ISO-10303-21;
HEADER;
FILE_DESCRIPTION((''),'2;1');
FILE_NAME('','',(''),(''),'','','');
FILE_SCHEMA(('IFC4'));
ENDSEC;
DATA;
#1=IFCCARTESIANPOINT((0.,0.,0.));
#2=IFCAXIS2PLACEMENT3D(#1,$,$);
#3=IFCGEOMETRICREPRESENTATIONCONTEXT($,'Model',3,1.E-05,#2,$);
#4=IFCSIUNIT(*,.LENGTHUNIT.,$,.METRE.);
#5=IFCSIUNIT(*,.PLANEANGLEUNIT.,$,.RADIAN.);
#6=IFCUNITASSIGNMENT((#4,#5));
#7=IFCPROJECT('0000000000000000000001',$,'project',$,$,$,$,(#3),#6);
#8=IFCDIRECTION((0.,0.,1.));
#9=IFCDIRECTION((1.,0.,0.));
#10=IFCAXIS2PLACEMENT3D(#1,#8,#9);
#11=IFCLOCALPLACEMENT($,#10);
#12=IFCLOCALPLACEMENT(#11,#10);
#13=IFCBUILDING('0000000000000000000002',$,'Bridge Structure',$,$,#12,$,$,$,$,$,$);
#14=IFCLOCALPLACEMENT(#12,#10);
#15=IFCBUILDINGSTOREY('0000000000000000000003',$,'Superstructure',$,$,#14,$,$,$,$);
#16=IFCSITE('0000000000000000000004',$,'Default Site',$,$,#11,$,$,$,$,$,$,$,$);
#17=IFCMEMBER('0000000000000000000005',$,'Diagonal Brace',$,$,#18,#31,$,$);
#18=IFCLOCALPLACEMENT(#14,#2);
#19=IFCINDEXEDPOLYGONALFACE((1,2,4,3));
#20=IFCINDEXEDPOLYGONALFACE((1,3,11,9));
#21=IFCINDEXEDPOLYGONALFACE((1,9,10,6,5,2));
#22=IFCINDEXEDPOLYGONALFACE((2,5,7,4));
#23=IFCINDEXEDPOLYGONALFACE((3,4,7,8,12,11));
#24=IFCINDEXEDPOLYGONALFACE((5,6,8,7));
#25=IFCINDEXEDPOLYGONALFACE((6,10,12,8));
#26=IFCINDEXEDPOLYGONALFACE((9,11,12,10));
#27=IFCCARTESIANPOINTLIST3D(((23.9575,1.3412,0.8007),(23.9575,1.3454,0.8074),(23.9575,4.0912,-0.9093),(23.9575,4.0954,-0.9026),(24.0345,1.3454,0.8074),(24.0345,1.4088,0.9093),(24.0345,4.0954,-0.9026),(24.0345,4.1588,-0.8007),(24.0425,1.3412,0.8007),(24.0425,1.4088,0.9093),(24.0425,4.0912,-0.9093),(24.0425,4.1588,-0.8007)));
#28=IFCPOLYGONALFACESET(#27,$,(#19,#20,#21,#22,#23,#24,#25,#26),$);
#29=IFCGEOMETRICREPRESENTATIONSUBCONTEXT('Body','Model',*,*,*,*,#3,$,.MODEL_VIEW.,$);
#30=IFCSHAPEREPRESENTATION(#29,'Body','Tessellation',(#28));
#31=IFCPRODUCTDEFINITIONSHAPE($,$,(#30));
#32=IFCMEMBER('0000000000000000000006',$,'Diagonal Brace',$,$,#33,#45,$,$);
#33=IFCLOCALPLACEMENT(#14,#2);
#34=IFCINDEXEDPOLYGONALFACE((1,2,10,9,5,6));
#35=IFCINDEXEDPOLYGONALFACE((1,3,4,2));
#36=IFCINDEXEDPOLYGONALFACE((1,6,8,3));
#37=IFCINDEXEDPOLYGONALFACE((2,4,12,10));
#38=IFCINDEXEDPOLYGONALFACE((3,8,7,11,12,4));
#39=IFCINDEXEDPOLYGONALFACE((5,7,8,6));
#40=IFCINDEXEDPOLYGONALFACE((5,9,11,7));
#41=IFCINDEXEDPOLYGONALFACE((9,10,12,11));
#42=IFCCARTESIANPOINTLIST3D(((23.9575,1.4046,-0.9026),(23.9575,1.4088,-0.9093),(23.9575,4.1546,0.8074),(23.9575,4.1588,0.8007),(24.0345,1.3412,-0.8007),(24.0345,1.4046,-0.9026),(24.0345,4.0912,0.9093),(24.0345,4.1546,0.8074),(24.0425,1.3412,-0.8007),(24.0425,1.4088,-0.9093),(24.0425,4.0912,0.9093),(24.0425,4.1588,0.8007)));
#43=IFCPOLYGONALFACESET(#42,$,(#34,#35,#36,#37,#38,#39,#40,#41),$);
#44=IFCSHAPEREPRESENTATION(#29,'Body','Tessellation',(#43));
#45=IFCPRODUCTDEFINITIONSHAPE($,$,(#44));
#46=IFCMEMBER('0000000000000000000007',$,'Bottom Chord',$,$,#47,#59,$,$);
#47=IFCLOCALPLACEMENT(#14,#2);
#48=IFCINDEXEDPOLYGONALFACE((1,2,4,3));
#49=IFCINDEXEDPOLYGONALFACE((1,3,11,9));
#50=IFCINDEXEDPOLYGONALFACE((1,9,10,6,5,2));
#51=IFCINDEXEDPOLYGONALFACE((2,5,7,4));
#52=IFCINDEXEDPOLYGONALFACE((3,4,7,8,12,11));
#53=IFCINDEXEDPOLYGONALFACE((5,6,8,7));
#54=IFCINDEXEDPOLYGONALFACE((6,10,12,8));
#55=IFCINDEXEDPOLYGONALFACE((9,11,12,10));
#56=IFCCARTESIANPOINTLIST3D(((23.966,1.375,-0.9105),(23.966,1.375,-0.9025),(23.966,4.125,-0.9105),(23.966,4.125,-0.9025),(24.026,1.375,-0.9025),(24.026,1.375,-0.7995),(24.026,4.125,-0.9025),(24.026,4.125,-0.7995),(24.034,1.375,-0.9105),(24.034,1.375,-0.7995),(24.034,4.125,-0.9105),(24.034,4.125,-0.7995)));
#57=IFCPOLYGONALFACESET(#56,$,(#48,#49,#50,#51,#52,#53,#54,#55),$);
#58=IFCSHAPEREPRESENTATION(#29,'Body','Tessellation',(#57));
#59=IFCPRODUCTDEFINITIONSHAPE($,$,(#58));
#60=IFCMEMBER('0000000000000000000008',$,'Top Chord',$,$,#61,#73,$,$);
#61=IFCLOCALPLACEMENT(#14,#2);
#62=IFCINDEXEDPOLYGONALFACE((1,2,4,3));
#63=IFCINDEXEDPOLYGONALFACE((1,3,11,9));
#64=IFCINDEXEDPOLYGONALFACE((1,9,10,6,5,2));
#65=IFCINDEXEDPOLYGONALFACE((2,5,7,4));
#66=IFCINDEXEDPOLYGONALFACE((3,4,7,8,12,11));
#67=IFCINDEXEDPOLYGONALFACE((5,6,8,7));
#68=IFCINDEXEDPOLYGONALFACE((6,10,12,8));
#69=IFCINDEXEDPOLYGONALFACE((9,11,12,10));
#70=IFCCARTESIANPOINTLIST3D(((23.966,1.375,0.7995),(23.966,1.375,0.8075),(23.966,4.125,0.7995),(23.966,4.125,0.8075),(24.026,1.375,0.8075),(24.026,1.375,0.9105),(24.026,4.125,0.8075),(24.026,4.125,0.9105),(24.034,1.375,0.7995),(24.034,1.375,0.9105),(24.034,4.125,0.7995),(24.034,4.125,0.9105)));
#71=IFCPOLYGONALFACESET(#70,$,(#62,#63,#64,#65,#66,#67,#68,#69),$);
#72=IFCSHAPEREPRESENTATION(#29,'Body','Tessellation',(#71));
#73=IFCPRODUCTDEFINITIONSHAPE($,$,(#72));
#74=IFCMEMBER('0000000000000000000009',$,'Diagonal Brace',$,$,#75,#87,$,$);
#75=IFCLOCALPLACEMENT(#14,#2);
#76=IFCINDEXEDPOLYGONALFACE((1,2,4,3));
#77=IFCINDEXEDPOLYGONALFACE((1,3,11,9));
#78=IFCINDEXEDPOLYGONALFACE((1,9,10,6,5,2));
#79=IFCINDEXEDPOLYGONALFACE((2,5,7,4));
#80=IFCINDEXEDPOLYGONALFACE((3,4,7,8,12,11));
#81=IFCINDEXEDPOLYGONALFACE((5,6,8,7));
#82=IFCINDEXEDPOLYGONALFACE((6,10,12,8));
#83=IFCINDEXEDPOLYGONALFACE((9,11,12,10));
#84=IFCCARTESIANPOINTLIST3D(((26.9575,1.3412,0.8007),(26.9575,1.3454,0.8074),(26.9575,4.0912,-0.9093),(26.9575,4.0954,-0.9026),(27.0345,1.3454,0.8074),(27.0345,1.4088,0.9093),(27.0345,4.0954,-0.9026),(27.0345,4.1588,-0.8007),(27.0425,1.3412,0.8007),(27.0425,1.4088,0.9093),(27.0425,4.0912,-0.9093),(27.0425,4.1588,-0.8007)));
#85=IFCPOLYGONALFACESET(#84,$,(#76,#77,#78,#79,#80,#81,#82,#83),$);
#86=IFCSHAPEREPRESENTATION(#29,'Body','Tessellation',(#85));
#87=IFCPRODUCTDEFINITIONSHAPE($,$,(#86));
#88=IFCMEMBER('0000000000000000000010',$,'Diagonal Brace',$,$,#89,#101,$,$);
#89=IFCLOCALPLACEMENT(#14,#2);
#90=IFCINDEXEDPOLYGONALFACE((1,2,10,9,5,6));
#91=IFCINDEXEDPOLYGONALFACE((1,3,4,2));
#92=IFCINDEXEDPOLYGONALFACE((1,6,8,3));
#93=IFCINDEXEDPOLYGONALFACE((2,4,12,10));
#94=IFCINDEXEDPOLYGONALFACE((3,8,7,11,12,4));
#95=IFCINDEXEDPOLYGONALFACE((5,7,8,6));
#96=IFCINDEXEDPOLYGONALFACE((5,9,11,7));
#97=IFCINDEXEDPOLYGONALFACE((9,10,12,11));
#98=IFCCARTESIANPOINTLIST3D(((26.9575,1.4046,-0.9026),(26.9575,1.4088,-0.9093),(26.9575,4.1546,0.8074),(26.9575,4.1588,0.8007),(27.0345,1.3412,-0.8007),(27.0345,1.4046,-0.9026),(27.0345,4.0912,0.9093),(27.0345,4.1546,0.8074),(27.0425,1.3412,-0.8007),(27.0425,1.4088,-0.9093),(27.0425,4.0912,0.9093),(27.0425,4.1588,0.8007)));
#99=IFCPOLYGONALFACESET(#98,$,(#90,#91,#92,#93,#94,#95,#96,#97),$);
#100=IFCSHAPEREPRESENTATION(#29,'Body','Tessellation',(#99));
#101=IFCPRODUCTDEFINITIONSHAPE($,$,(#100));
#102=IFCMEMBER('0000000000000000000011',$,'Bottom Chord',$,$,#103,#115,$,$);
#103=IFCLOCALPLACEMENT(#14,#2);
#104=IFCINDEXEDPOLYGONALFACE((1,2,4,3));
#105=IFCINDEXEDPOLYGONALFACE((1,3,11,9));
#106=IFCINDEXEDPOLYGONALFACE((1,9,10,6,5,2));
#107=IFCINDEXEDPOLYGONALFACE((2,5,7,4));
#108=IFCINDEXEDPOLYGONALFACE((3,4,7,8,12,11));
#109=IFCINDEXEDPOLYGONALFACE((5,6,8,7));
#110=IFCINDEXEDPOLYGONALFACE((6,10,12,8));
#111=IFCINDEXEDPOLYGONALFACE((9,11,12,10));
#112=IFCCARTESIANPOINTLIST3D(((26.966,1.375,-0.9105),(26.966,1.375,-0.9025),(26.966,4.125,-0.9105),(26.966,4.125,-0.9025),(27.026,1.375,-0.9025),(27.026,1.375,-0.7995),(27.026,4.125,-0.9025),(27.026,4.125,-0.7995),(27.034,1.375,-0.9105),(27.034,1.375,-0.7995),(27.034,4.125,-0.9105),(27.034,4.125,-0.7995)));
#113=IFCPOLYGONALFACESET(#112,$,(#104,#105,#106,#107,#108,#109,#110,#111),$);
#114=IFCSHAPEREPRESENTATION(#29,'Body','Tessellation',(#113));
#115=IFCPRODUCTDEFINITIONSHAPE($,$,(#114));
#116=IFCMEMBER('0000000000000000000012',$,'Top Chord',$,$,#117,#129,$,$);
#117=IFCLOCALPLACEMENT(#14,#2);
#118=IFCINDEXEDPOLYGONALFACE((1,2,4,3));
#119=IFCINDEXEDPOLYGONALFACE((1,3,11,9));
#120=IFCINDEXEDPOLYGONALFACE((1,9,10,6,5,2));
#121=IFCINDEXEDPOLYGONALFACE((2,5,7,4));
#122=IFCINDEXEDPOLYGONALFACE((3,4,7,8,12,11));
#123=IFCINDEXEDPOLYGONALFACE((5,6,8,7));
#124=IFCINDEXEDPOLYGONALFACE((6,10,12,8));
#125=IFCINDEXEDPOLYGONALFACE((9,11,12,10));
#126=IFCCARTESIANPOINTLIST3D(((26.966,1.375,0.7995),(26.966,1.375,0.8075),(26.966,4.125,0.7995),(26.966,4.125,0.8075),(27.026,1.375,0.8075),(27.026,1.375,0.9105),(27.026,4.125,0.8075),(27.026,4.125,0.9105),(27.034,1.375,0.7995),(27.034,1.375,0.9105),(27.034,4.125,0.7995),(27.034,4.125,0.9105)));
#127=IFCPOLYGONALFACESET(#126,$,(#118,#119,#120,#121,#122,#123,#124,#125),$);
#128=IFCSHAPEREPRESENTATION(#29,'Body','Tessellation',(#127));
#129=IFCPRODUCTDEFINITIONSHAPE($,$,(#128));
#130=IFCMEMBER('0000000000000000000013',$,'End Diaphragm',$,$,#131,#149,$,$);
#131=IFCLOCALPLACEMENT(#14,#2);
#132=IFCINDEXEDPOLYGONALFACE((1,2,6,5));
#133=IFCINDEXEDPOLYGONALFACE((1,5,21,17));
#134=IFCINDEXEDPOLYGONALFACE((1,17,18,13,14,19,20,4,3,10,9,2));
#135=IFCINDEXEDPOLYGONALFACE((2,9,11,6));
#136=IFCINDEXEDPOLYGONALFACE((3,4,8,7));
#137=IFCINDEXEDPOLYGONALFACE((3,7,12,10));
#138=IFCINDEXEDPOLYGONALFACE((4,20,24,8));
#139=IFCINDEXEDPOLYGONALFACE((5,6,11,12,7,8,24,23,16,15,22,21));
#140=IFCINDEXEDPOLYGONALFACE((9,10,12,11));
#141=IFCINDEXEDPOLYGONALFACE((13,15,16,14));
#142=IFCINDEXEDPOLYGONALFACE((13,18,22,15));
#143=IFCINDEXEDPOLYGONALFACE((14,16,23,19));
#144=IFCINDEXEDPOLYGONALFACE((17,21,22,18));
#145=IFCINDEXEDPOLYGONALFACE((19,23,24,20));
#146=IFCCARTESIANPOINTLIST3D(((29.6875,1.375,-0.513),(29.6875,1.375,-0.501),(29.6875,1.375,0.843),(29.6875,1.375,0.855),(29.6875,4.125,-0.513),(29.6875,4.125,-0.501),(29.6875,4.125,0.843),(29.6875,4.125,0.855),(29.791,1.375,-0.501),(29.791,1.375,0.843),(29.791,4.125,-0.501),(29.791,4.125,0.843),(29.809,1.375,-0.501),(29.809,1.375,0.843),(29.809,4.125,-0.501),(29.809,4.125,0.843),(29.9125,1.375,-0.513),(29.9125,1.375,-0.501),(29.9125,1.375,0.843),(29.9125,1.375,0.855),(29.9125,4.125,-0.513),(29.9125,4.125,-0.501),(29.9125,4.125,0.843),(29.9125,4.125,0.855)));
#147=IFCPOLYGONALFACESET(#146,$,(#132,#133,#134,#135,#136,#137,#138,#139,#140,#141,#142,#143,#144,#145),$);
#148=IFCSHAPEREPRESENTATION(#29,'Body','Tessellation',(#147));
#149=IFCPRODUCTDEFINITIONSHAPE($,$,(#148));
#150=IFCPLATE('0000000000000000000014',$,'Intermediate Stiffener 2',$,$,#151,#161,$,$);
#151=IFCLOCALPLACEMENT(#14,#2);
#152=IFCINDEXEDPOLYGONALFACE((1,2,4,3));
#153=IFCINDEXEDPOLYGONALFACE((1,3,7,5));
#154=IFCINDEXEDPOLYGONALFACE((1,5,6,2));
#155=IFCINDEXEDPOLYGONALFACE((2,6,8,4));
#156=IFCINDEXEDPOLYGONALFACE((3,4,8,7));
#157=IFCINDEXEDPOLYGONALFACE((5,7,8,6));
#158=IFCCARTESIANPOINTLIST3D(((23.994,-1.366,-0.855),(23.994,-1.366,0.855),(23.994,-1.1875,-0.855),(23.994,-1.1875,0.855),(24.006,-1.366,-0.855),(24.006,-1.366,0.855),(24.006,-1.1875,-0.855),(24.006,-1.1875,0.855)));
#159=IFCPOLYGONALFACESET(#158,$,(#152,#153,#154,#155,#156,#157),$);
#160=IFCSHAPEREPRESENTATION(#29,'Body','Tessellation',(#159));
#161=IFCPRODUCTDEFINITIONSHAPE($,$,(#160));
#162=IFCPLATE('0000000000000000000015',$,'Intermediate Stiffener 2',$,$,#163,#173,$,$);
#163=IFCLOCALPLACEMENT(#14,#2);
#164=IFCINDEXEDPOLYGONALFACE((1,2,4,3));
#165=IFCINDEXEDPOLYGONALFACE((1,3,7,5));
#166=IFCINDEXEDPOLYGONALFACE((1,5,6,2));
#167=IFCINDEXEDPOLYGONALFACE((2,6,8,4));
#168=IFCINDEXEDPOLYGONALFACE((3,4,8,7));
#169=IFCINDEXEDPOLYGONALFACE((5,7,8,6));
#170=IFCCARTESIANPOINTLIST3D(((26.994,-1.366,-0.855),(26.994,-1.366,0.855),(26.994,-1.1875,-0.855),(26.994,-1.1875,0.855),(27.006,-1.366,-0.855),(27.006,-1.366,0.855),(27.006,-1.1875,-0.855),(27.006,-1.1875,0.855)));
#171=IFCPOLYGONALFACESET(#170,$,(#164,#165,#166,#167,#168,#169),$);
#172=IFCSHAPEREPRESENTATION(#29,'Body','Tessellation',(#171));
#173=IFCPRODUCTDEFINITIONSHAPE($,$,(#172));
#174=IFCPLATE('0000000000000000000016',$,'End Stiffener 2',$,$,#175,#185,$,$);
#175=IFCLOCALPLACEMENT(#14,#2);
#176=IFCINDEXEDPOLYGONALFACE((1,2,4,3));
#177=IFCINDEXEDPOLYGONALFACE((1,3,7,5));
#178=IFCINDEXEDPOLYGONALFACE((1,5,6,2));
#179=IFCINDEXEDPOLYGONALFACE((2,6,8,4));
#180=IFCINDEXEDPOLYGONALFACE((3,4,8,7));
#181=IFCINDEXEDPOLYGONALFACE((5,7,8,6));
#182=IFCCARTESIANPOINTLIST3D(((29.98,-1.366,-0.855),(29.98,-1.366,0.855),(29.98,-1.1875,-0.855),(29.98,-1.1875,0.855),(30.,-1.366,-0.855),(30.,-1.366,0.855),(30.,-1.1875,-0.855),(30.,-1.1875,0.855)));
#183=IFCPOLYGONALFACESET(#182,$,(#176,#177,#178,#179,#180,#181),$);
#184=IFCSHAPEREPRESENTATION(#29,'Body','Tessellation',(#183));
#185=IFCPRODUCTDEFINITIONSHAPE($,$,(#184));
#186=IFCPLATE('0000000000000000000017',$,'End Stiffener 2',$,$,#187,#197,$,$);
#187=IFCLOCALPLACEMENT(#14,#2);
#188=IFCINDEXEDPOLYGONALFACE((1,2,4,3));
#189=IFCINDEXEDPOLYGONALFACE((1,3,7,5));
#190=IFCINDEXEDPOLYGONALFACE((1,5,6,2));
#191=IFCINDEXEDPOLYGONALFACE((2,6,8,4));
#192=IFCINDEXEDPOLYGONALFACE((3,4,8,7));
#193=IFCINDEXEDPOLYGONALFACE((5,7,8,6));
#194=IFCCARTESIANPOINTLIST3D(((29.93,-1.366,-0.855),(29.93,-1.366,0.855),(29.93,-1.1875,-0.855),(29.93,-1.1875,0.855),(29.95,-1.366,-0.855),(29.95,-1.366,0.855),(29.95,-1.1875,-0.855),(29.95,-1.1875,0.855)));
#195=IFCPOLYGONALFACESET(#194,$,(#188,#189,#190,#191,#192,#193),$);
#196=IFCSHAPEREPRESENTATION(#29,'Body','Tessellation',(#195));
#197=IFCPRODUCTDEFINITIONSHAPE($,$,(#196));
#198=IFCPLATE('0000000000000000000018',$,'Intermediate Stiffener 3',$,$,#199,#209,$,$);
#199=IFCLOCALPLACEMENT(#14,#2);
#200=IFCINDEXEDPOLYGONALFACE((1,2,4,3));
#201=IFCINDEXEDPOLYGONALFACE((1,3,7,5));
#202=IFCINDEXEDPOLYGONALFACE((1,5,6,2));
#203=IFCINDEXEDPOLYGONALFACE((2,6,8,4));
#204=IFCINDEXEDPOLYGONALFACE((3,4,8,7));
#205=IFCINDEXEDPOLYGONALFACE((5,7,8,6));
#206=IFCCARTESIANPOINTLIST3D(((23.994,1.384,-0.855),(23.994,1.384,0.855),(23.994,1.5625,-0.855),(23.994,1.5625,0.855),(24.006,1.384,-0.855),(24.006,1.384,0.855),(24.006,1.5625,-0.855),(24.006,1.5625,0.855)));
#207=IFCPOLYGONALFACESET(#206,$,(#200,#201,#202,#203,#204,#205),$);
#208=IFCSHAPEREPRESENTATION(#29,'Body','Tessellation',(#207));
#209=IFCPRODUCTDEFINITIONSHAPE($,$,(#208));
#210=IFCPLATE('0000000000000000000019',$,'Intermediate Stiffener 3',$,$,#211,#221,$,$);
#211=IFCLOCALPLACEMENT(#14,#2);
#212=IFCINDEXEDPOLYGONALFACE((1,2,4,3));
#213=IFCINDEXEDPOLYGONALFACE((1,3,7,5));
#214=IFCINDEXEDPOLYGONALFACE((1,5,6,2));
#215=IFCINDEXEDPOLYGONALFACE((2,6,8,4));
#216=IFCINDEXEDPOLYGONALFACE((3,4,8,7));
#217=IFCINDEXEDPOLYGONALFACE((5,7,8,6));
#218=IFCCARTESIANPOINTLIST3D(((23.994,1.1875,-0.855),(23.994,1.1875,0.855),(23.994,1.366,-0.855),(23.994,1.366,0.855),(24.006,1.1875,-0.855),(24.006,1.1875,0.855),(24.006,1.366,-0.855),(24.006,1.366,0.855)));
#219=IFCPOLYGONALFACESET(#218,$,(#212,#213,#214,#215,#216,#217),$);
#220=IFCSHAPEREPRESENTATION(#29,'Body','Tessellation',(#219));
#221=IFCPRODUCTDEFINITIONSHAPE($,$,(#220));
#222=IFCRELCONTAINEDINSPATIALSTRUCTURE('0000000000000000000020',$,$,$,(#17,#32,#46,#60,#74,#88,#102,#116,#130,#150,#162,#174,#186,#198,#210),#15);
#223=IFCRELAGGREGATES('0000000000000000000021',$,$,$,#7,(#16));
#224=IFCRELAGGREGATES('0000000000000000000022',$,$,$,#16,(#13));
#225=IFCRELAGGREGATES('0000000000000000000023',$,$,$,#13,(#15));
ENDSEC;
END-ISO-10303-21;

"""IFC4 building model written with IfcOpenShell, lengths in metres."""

from ifc_helpers import new_model, si_unit, frame, origin, origin_with_axes, origin_2d_with_axis, place, context, subcontext, project, spatial, rectangle, i_section, l_section, extrude, element, save


model = new_model("IFC4")

# Units and contexts
model_context = context("Model", 3, precision=1e-05, world=origin())
body_context = subcontext(model_context, "Body", "Model", "MODEL_VIEW")
ifc_project = project(units=[si_unit("LENGTHUNIT", "METRE"), si_unit("PLANEANGLEUNIT", "RADIAN")], contexts=[model_context])

# Site, building, storey
site_placement = place(None, origin_with_axes())
site = spatial("IfcSite", under=ifc_project, at=site_placement, Name="Default Site")
building_placement = place(site_placement, origin_with_axes())
building = spatial("IfcBuilding", under=site, at=building_placement, Name="Bridge Structure")
storey_placement = place(building_placement, origin_with_axes())
storey = spatial("IfcBuildingStorey", under=building, at=storey_placement, Name="Superstructure")

# Members
for number, where, z_axis, x_axis, name in (
    (1, (24.0, 1.375, 0.855), (0.0, 0.84921, -0.528055), (-1.0, 0.0, 0.0), "Diagonal Brace"),
    (2, (24.0, 1.375, -0.855), (0.0, 0.84921, 0.528055), (-1.0, 0.0, 0.0), "Diagonal Brace"),
):
    element("IfcMember", number, at=place(storey_placement, frame(where, z_axis=z_axis, x_axis=x_axis)), inside=storey, Name=name, context=body_context, shape_type="SweptSolid", body=[
        extrude(l_section(Depth=0.128, Width=0.085, Thickness=0.008, at=origin_2d_with_axis()), origin_with_axes(), (0.0, 0.0, 1.0), 3.2383),
    ])
for number, where, z_axis, x_axis, name in (
    (3, (24.0, 1.375, -0.855), (0.0, 1.0, 0.0), (-1.0, 0.0, 0.0), "Bottom Chord"),
    (4, (24.0, 1.375, 0.855), (0.0, 1.0, 0.0), (-1.0, 0.0, 0.0), "Top Chord"),
):
    element("IfcMember", number, at=place(storey_placement, frame(where, z_axis=z_axis, x_axis=x_axis)), inside=storey, Name=name, context=body_context, shape_type="SweptSolid", body=[
        extrude(l_section(Depth=0.111, Width=0.068, Thickness=0.008, at=origin_2d_with_axis()), origin_with_axes(), (0.0, 0.0, 1.0), 2.75),
    ])
for number, where, z_axis, x_axis, name in (
    (5, (27.0, 1.375, 0.855), (0.0, 0.84921, -0.528055), (-1.0, 0.0, 0.0), "Diagonal Brace"),
    (6, (27.0, 1.375, -0.855), (0.0, 0.84921, 0.528055), (-1.0, 0.0, 0.0), "Diagonal Brace"),
):
    element("IfcMember", number, at=place(storey_placement, frame(where, z_axis=z_axis, x_axis=x_axis)), inside=storey, Name=name, context=body_context, shape_type="SweptSolid", body=[
        extrude(l_section(Depth=0.128, Width=0.085, Thickness=0.008, at=origin_2d_with_axis()), origin_with_axes(), (0.0, 0.0, 1.0), 3.2383),
    ])
for number, where, z_axis, x_axis, name in (
    (7, (27.0, 1.375, -0.855), (0.0, 1.0, 0.0), (-1.0, 0.0, 0.0), "Bottom Chord"),
    (8, (27.0, 1.375, 0.855), (0.0, 1.0, 0.0), (-1.0, 0.0, 0.0), "Top Chord"),
):
    element("IfcMember", number, at=place(storey_placement, frame(where, z_axis=z_axis, x_axis=x_axis)), inside=storey, Name=name, context=body_context, shape_type="SweptSolid", body=[
        extrude(l_section(Depth=0.111, Width=0.068, Thickness=0.008, at=origin_2d_with_axis()), origin_with_axes(), (0.0, 0.0, 1.0), 2.75),
    ])
member_placement = place(storey_placement, frame((29.8, 1.375, 0.171), z_axis=(0.0, 1.0, 0.0), x_axis=(-1.0, 0.0, 0.0)))
element("IfcMember", 9, at=member_placement, inside=storey, Name="End Diaphragm", context=body_context, shape_type="SweptSolid", body=[
    extrude(i_section(OverallWidth=0.225, OverallDepth=1.368, WebThickness=0.018, FlangeThickness=0.012, at=origin_2d_with_axis()), origin_with_axes(), (0.0, 0.0, 1.0), 2.75),
])

# Plates
for number, where, z_axis, x_axis, name in (
    (10, (24.0, -1.2768, -0.855), (0.0, 0.0, 1.0), (1.0, 0.0, 0.0), "Intermediate Stiffener 2"),
    (11, (27.0, -1.2768, -0.855), (0.0, 0.0, 1.0), (1.0, 0.0, 0.0), "Intermediate Stiffener 2"),
):
    element("IfcPlate", number, at=place(storey_placement, frame(where, z_axis=z_axis, x_axis=x_axis)), inside=storey, Name=name, context=body_context, shape_type="SweptSolid", body=[
        extrude(rectangle(XDim=0.012, YDim=0.1785, at=origin_2d_with_axis()), origin_with_axes(), (0.0, 0.0, 1.0), 1.71),
    ])
for number, where, z_axis, x_axis, name in (
    (12, (29.99, -1.2768, -0.855), (0.0, 0.0, 1.0), (1.0, 0.0, 0.0), "End Stiffener 2"),
    (13, (29.94, -1.2768, -0.855), (0.0, 0.0, 1.0), (1.0, 0.0, 0.0), "End Stiffener 2"),
):
    element("IfcPlate", number, at=place(storey_placement, frame(where, z_axis=z_axis, x_axis=x_axis)), inside=storey, Name=name, context=body_context, shape_type="SweptSolid", body=[
        extrude(rectangle(XDim=0.02, YDim=0.1785, at=origin_2d_with_axis()), origin_with_axes(), (0.0, 0.0, 1.0), 1.71),
    ])
for number, where, z_axis, x_axis, name in (
    (14, (24.0, 1.4732, -0.855), (0.0, 0.0, 1.0), (1.0, 0.0, 0.0), "Intermediate Stiffener 3"),
    (15, (24.0, 1.2768, -0.855), (0.0, 0.0, 1.0), (1.0, 0.0, 0.0), "Intermediate Stiffener 3"),
):
    element("IfcPlate", number, at=place(storey_placement, frame(where, z_axis=z_axis, x_axis=x_axis)), inside=storey, Name=name, context=body_context, shape_type="SweptSolid", body=[
        extrude(rectangle(XDim=0.012, YDim=0.1785, at=origin_2d_with_axis()), origin_with_axes(), (0.0, 0.0, 1.0), 1.71),
    ])

save(model, "model.ifc")
